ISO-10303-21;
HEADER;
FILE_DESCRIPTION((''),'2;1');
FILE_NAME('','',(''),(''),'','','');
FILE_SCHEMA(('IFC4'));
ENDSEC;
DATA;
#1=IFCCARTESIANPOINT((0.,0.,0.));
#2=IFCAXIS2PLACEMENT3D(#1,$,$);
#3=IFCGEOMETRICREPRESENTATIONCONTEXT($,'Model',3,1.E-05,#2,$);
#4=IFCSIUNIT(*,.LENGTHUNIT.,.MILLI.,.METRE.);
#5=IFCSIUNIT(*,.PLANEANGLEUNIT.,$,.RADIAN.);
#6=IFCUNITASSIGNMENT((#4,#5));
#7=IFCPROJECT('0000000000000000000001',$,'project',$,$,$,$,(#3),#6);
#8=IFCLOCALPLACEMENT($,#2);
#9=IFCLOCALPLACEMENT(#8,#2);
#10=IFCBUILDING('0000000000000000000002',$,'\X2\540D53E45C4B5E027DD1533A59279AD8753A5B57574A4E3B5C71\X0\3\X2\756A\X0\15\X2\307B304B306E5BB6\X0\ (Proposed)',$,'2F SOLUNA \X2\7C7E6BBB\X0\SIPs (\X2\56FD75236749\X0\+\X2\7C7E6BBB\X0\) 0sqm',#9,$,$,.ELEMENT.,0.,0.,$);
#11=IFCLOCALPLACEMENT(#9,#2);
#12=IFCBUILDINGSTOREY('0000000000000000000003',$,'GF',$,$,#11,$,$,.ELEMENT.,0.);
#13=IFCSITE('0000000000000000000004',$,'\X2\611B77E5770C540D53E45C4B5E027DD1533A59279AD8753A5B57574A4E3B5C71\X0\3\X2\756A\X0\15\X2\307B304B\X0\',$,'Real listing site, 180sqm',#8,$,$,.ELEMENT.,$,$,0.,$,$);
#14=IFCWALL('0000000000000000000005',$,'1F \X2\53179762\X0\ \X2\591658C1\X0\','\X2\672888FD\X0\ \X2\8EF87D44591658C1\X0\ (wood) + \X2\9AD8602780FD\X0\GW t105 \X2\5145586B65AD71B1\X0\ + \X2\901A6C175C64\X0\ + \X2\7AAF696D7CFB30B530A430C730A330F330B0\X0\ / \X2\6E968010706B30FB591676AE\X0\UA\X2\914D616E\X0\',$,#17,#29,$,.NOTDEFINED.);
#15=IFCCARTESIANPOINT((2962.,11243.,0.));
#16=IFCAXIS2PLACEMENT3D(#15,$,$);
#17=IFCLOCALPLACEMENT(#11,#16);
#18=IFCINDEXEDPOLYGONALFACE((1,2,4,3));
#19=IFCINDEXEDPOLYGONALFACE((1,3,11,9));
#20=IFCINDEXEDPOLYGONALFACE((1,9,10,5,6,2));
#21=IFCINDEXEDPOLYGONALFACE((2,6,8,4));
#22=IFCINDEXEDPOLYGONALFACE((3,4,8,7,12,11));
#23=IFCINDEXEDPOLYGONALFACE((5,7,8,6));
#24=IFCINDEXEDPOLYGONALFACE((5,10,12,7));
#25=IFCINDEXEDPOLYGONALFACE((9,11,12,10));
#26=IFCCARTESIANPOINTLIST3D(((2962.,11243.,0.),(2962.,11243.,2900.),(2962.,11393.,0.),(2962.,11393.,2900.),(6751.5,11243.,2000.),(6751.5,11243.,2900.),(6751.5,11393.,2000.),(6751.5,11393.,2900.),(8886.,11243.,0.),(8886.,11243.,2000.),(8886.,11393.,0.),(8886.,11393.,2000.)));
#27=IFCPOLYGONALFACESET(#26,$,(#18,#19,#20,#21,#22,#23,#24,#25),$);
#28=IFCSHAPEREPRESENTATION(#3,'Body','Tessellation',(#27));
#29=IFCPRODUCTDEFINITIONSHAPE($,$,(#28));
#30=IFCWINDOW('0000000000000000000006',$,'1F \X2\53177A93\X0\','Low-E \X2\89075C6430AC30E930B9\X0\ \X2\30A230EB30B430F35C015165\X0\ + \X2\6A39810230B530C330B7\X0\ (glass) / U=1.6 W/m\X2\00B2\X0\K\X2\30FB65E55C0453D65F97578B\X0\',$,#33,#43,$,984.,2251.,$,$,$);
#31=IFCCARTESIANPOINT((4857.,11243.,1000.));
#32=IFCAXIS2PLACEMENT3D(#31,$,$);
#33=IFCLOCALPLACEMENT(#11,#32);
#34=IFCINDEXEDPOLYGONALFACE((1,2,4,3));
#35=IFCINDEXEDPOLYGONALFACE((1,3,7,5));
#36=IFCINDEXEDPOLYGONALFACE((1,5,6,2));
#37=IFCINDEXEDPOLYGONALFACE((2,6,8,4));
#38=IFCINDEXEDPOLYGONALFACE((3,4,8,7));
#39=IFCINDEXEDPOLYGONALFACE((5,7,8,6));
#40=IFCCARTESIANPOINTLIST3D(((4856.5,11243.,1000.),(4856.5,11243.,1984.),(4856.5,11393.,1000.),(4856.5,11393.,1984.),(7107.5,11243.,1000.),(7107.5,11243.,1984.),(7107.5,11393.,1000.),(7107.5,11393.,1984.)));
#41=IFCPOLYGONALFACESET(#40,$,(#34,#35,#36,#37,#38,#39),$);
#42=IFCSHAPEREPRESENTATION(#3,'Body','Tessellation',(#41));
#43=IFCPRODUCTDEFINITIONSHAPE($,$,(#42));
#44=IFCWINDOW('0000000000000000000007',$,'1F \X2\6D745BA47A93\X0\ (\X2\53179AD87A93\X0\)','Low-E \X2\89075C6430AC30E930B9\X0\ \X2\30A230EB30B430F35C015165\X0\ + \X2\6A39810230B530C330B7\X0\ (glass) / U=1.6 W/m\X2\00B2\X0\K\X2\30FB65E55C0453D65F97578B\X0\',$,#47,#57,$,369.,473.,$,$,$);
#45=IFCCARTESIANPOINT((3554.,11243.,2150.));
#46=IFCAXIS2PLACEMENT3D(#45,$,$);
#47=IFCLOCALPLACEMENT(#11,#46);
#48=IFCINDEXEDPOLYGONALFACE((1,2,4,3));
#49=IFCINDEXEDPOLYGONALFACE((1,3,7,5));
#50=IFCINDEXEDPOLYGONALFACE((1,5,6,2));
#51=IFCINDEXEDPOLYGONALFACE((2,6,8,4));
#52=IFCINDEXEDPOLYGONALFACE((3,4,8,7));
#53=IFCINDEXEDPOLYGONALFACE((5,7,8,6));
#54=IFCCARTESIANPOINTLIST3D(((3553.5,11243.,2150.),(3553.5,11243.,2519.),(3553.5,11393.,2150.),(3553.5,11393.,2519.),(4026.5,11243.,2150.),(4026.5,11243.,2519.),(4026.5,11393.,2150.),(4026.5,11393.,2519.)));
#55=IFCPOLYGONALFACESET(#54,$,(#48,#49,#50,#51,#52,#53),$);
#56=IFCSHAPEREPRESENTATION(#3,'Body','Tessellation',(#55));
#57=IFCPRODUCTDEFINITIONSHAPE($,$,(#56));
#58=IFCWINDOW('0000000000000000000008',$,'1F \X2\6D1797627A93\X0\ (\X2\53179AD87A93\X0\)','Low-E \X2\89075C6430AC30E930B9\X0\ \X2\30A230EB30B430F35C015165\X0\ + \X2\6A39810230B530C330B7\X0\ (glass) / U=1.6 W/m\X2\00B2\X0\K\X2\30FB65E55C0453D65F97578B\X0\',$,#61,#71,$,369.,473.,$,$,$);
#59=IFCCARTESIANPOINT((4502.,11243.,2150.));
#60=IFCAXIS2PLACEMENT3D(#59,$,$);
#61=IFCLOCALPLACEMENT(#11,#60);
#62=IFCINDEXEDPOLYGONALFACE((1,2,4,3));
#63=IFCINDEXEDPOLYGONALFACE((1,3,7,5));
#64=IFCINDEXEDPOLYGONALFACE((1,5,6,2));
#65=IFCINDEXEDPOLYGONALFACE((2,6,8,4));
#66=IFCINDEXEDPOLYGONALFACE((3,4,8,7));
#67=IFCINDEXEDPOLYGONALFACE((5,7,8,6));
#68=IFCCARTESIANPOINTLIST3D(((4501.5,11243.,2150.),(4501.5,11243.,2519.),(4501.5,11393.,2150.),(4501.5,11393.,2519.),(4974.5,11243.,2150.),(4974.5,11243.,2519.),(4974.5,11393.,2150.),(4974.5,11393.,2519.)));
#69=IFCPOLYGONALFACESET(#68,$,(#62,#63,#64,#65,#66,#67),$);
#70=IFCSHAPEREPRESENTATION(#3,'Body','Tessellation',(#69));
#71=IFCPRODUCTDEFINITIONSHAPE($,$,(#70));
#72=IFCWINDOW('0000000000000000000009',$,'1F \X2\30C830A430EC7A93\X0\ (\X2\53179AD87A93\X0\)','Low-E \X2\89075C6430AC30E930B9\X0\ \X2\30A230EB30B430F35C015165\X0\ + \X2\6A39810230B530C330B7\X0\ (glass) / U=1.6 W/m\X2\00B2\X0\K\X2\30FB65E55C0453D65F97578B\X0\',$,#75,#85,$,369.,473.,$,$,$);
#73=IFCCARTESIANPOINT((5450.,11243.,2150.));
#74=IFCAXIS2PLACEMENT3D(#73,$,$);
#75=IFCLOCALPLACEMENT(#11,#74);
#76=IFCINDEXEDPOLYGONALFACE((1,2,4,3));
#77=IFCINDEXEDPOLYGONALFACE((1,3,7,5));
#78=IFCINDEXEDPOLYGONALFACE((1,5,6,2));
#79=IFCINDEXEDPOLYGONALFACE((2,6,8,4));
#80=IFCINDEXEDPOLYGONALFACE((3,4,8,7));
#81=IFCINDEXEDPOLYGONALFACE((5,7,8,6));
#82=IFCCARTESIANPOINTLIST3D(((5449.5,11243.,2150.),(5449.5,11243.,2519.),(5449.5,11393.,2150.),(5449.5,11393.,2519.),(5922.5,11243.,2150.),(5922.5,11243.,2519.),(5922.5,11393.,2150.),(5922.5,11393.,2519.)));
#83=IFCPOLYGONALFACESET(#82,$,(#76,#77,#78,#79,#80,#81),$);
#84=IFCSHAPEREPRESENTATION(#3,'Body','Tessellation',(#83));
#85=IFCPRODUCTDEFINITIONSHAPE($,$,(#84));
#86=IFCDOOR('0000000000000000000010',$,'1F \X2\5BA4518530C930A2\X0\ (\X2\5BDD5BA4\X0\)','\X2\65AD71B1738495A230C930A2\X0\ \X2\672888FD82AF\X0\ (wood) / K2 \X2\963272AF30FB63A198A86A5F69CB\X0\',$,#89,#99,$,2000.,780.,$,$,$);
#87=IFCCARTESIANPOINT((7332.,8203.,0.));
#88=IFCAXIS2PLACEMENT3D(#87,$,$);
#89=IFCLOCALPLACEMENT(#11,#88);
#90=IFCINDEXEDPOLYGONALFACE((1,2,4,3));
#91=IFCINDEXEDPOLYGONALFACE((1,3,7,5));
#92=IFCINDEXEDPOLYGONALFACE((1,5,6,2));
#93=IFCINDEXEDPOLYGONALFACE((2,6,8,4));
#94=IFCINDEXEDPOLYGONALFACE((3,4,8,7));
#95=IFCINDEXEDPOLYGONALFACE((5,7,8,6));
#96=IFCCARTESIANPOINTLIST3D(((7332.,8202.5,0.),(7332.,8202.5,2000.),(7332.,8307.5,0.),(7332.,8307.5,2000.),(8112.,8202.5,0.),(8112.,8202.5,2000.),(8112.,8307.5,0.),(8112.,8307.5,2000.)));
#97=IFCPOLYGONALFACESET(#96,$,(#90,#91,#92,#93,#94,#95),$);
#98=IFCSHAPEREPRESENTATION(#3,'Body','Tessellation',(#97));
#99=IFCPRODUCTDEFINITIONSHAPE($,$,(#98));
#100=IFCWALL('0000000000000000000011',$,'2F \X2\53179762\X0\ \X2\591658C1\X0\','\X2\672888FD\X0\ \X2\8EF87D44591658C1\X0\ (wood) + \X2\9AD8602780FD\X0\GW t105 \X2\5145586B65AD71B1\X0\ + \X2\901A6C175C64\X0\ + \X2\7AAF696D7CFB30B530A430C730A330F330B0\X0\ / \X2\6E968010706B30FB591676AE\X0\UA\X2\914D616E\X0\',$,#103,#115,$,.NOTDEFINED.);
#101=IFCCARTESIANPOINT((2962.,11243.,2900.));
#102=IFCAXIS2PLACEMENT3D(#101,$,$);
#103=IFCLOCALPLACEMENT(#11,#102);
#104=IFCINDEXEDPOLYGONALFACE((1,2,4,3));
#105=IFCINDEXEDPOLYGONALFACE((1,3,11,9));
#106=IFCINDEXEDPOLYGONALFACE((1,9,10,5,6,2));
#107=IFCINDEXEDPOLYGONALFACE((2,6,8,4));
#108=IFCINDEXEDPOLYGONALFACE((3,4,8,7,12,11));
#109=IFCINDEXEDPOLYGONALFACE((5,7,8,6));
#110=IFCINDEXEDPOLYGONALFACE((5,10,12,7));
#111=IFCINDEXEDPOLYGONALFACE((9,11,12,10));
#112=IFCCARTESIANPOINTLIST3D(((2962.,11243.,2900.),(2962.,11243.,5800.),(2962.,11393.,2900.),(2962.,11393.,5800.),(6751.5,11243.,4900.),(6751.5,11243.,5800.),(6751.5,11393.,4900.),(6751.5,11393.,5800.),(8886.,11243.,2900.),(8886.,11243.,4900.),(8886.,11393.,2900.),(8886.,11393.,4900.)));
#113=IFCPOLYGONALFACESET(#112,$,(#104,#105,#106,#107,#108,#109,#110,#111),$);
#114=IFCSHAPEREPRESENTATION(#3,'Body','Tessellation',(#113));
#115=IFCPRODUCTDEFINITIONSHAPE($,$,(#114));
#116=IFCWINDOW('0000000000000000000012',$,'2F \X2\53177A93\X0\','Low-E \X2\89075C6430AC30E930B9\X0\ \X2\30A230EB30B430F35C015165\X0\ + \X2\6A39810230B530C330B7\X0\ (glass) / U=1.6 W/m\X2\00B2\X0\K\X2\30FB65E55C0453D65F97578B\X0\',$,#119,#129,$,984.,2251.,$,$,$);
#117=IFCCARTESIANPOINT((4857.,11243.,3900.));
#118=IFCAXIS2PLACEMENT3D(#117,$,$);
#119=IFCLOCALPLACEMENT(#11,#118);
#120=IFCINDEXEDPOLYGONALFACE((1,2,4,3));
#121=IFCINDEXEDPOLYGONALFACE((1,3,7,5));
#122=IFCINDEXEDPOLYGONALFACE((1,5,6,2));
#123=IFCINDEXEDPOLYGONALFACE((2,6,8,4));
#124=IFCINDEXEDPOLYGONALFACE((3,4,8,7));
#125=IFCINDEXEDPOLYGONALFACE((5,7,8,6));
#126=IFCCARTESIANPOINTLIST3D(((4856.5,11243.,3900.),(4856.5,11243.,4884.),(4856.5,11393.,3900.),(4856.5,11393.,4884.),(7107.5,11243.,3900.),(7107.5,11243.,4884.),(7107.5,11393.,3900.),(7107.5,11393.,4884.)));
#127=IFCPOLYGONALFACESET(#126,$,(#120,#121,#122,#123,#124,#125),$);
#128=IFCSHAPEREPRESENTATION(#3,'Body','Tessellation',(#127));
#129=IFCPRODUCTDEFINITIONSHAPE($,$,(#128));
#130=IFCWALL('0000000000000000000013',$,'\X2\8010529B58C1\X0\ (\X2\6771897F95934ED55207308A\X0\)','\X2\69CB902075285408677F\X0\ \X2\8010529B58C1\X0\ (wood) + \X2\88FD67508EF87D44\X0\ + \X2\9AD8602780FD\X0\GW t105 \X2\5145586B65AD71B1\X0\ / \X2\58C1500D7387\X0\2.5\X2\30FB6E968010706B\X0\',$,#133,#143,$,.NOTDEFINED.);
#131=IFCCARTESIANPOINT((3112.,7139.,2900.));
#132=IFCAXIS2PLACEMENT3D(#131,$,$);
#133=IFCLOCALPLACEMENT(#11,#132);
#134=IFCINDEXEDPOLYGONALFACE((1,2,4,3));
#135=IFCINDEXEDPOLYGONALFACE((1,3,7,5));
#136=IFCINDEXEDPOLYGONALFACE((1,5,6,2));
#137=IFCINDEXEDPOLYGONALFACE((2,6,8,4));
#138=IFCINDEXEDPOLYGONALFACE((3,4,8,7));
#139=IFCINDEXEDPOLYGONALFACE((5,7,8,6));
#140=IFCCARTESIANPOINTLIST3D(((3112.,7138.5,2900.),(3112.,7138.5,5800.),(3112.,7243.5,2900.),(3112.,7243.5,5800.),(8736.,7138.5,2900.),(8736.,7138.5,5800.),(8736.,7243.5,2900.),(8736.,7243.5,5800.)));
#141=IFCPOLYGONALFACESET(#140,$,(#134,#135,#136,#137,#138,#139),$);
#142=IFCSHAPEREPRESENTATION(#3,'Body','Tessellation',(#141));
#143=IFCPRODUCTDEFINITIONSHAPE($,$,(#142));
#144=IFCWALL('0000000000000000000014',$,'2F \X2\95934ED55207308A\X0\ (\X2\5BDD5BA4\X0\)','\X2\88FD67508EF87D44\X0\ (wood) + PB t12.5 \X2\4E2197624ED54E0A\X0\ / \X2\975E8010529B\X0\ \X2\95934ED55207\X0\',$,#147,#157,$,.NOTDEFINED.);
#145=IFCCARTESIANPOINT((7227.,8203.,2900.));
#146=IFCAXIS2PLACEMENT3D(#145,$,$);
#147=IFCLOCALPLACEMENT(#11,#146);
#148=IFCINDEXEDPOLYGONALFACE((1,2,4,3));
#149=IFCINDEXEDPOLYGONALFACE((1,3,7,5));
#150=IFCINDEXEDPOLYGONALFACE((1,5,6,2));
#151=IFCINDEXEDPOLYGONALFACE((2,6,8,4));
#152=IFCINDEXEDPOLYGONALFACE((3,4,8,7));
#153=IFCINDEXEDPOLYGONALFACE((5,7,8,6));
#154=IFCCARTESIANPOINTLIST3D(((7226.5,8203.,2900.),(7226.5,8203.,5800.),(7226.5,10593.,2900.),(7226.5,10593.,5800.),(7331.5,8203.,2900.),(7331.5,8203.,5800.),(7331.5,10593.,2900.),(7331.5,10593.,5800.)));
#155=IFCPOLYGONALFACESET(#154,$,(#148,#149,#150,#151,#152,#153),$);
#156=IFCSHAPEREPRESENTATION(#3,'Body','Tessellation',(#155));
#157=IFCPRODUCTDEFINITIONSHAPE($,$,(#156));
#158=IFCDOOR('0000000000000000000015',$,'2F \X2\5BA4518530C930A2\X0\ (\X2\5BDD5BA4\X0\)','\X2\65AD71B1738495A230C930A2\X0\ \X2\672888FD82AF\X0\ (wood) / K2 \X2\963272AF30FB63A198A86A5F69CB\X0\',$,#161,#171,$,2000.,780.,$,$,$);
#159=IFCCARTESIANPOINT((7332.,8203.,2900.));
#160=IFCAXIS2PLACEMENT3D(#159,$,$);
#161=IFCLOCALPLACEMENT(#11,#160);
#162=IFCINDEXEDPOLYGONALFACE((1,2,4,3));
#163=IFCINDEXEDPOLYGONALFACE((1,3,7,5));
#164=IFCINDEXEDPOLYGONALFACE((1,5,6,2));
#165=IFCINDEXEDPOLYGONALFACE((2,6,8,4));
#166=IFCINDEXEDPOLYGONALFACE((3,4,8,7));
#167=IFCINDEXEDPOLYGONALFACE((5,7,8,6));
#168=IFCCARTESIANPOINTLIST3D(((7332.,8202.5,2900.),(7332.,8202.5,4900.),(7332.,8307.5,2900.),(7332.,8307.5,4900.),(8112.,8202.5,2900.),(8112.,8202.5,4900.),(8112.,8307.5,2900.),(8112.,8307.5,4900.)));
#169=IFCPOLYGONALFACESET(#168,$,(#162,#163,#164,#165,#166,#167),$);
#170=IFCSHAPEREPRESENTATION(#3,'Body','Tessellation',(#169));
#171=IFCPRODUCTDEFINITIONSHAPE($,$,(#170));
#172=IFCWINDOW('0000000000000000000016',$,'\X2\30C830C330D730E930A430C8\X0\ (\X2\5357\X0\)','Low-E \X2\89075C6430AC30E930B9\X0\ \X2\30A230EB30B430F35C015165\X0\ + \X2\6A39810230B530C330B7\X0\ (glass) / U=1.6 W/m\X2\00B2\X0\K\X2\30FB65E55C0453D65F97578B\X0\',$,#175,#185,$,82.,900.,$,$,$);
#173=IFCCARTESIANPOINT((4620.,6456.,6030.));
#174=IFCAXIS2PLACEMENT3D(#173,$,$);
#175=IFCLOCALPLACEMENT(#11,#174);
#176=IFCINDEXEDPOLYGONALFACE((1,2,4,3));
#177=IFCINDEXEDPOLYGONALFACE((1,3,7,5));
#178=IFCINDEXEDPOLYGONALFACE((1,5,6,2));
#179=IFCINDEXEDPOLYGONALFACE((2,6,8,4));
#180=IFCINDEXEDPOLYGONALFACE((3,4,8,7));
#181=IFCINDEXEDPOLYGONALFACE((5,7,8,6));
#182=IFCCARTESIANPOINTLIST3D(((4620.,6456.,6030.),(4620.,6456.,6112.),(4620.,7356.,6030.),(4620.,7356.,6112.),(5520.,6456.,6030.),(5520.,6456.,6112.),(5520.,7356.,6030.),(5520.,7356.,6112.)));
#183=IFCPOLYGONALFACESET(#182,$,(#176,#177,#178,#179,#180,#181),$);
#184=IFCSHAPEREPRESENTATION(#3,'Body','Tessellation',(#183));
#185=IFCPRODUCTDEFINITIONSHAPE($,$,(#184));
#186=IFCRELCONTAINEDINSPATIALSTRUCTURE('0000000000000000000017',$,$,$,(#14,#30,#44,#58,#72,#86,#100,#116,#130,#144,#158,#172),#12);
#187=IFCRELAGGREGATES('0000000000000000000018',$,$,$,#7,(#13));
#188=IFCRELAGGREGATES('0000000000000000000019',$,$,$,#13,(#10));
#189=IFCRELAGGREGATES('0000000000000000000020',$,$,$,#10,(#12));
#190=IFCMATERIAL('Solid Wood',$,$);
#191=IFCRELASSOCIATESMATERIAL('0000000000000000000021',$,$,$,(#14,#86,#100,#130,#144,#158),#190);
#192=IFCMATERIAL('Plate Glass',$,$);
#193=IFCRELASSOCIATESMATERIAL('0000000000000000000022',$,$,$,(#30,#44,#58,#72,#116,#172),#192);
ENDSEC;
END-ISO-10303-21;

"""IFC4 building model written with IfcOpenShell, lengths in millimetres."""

from ifc_helpers import new_model, si_unit, frame, frame_2d, origin, place, context, project, spatial, rectangle, extrude, material, element, fill, save


model = new_model("IFC4")

# Units and contexts
model_context = context("Model", 3, precision=1e-05, world=origin())
ifc_project = project(units=[si_unit("LENGTHUNIT", "METRE", prefix="MILLI"), si_unit("PLANEANGLEUNIT", "RADIAN")], contexts=[model_context])

# Site, building, storey
site_placement = place(None, origin())
site = spatial("IfcSite", under=ifc_project, at=site_placement, Name="愛知県名古屋市緑区大高町字坊主山3番15ほか", ObjectType="Real listing site, 180sqm", CompositionType="ELEMENT", RefElevation=0.0)
building_placement = place(site_placement, origin())
building = spatial("IfcBuilding", under=site, at=building_placement, Name="名古屋市緑区大高町字坊主山3番15ほかの家 (Proposed)", ObjectType="2F SOLUNA 籾殻SIPs (国産杉+籾殻) 0sqm", CompositionType="ELEMENT", ElevationOfRefHeight=0.0, ElevationOfTerrain=0.0)
storey_placement = place(building_placement, origin())
storey = spatial("IfcBuildingStorey", under=building, at=storey_placement, Name="GF", CompositionType="ELEMENT", Elevation=0.0)

# Wall, openings, windows
ifc_material_1 = material(Name="Solid Wood")
wall_1_placement = place(storey_placement, frame((2962.0, 11243.0, 0.0)))
wall_1 = element("IfcWall", 1, at=wall_1_placement, inside=storey, material=ifc_material_1, Name="1F 北面 外壁", Description="木製 軸組外壁 (wood) + 高性能GW t105 充填断熱 + 通気層 + 窯業系サイディング / 準耐火・外皮UA配慮", PredefinedType="NOTDEFINED", context=model_context, shape_type="SweptSolid", body=[
    extrude(rectangle(XDim=5924.0, YDim=150.0, at=frame_2d((2962.0, 75.0))), frame((2962.0, 11243.0, 0.0)), (0.0, 0.0, 1.0), 2900.0),
])
opening_1_placement = place(storey_placement, frame((4857.0, 11243.0, 1000.0)))
opening_1 = element("IfcOpeningElement", 2, at=opening_1_placement, cuts=wall_1, PredefinedType="NOTDEFINED", context=model_context, shape_type="SweptSolid", body=[
    extrude(rectangle(XDim=2251.0, YDim=150.0, at=frame_2d((1125.0, 75.0))), frame((4857.0, 11243.0, 1000.0)), (0.0, 0.0, 1.0), 984.0),
])
opening_2_placement = place(storey_placement, frame((3554.0, 11243.0, 2150.0)))
opening_2 = element("IfcOpeningElement", 3, at=opening_2_placement, cuts=wall_1, PredefinedType="NOTDEFINED", context=model_context, shape_type="SweptSolid", body=[
    extrude(rectangle(XDim=473.0, YDim=150.0, at=frame_2d((236.0, 75.0))), frame((3554.0, 11243.0, 2150.0)), (0.0, 0.0, 1.0), 369.0),
])
opening_3_placement = place(storey_placement, frame((4502.0, 11243.0, 2150.0)))
opening_3 = element("IfcOpeningElement", 4, at=opening_3_placement, cuts=wall_1, PredefinedType="NOTDEFINED", context=model_context, shape_type="SweptSolid", body=[
    extrude(rectangle(XDim=473.0, YDim=150.0, at=frame_2d((236.0, 75.0))), frame((4502.0, 11243.0, 2150.0)), (0.0, 0.0, 1.0), 369.0),
])
opening_4_placement = place(storey_placement, frame((5450.0, 11243.0, 2150.0)))
opening_4 = element("IfcOpeningElement", 5, at=opening_4_placement, cuts=wall_1, PredefinedType="NOTDEFINED", context=model_context, shape_type="SweptSolid", body=[
    extrude(rectangle(XDim=473.0, YDim=150.0, at=frame_2d((236.0, 75.0))), frame((5450.0, 11243.0, 2150.0)), (0.0, 0.0, 1.0), 369.0),
])
ifc_material_2 = material(Name="Plate Glass")
window_1_placement = place(storey_placement, frame((4857.0, 11243.0, 1000.0)))
window_1 = element("IfcWindow", 6, at=window_1_placement, inside=storey, material=ifc_material_2, Name="1F 北窓", Description="Low-E 複層ガラス アルゴン封入 + 樹脂サッシ (glass) / U=1.6 W/m²K・日射取得型", OverallHeight=984.0, OverallWidth=2251.0, context=model_context, shape_type="SweptSolid", body=[
    extrude(rectangle(XDim=2251.0, YDim=150.0, at=frame_2d((1125.0, 75.0))), frame((4857.0, 11243.0, 1000.0)), (0.0, 0.0, 1.0), 984.0),
])
fill(opening_1, window_1)
window_2_placement = place(storey_placement, frame((3554.0, 11243.0, 2150.0)))
window_2 = element("IfcWindow", 7, at=window_2_placement, inside=storey, material=ifc_material_2, Name="1F 浴室窓 (北高窓)", Description="Low-E 複層ガラス アルゴン封入 + 樹脂サッシ (glass) / U=1.6 W/m²K・日射取得型", OverallHeight=369.0, OverallWidth=473.0, context=model_context, shape_type="SweptSolid", body=[
    extrude(rectangle(XDim=473.0, YDim=150.0, at=frame_2d((236.0, 75.0))), frame((3554.0, 11243.0, 2150.0)), (0.0, 0.0, 1.0), 369.0),
])
fill(opening_2, window_2)
window_3_placement = place(storey_placement, frame((4502.0, 11243.0, 2150.0)))
window_3 = element("IfcWindow", 8, at=window_3_placement, inside=storey, material=ifc_material_2, Name="1F 洗面窓 (北高窓)", Description="Low-E 複層ガラス アルゴン封入 + 樹脂サッシ (glass) / U=1.6 W/m²K・日射取得型", OverallHeight=369.0, OverallWidth=473.0, context=model_context, shape_type="SweptSolid", body=[
    extrude(rectangle(XDim=473.0, YDim=150.0, at=frame_2d((236.0, 75.0))), frame((4502.0, 11243.0, 2150.0)), (0.0, 0.0, 1.0), 369.0),
])
fill(opening_3, window_3)
window_4_placement = place(storey_placement, frame((5450.0, 11243.0, 2150.0)))
window_4 = element("IfcWindow", 9, at=window_4_placement, inside=storey, material=ifc_material_2, Name="1F トイレ窓 (北高窓)", Description="Low-E 複層ガラス アルゴン封入 + 樹脂サッシ (glass) / U=1.6 W/m²K・日射取得型", OverallHeight=369.0, OverallWidth=473.0, context=model_context, shape_type="SweptSolid", body=[
    extrude(rectangle(XDim=473.0, YDim=150.0, at=frame_2d((236.0, 75.0))), frame((5450.0, 11243.0, 2150.0)), (0.0, 0.0, 1.0), 369.0),
])
fill(opening_4, window_4)

# Door
door_1_placement = place(storey_placement, frame((7332.0, 8203.0, 0.0)))
element("IfcDoor", 10, at=door_1_placement, inside=storey, material=ifc_material_1, Name="1F 室内ドア (寝室)", Description="断熱玄関ドア 木製芯 (wood) / K2 防犯・採風機構", OverallHeight=2000.0, OverallWidth=780.0, context=model_context, shape_type="SweptSolid", body=[
    extrude(rectangle(XDim=780.0, YDim=105.0, at=frame_2d((390.0, 52.0))), frame((7332.0, 8203.0, 0.0)), (0.0, 0.0, 1.0), 2000.0),
])

# Wall, opening, window
wall_2_placement = place(storey_placement, frame((2962.0, 11243.0, 2900.0)))
wall_2 = element("IfcWall", 11, at=wall_2_placement, inside=storey, material=ifc_material_1, Name="2F 北面 外壁", Description="木製 軸組外壁 (wood) + 高性能GW t105 充填断熱 + 通気層 + 窯業系サイディング / 準耐火・外皮UA配慮", PredefinedType="NOTDEFINED", context=model_context, shape_type="SweptSolid", body=[
    extrude(rectangle(XDim=5924.0, YDim=150.0, at=frame_2d((2962.0, 75.0))), frame((2962.0, 11243.0, 2900.0)), (0.0, 0.0, 1.0), 2900.0),
])
opening_5_placement = place(storey_placement, frame((4857.0, 11243.0, 3900.0)))
opening_5 = element("IfcOpeningElement", 12, at=opening_5_placement, cuts=wall_2, PredefinedType="NOTDEFINED", context=model_context, shape_type="SweptSolid", body=[
    extrude(rectangle(XDim=2251.0, YDim=150.0, at=frame_2d((1125.0, 75.0))), frame((4857.0, 11243.0, 3900.0)), (0.0, 0.0, 1.0), 984.0),
])
window_5_placement = place(storey_placement, frame((4857.0, 11243.0, 3900.0)))
window_5 = element("IfcWindow", 13, at=window_5_placement, inside=storey, material=ifc_material_2, Name="2F 北窓", Description="Low-E 複層ガラス アルゴン封入 + 樹脂サッシ (glass) / U=1.6 W/m²K・日射取得型", OverallHeight=984.0, OverallWidth=2251.0, context=model_context, shape_type="SweptSolid", body=[
    extrude(rectangle(XDim=2251.0, YDim=150.0, at=frame_2d((1125.0, 75.0))), frame((4857.0, 11243.0, 3900.0)), (0.0, 0.0, 1.0), 984.0),
])
fill(opening_5, window_5)

# Walls
wall_3_placement = place(storey_placement, frame((3112.0, 7139.0, 2900.0)))
element("IfcWall", 14, at=wall_3_placement, inside=storey, material=ifc_material_1, Name="耐力壁 (東西間仕切り)", Description="構造用合板 耐力壁 (wood) + 製材軸組 + 高性能GW t105 充填断熱 / 壁倍率2.5・準耐火", PredefinedType="NOTDEFINED", context=model_context, shape_type="SweptSolid", body=[
    extrude(rectangle(XDim=5624.0, YDim=105.0, at=frame_2d((2812.0, 52.0))), frame((3112.0, 7139.0, 2900.0)), (0.0, 0.0, 1.0), 2900.0),
])
wall_4_placement = place(storey_placement, frame((7227.0, 8203.0, 2900.0)))
element("IfcWall", 15, at=wall_4_placement, inside=storey, material=ifc_material_1, Name="2F 間仕切り (寝室)", Description="製材軸組 (wood) + PB t12.5 両面仕上 / 非耐力 間仕切", PredefinedType="NOTDEFINED", context=model_context, shape_type="SweptSolid", body=[
    extrude(rectangle(XDim=105.0, YDim=2390.0, at=frame_2d((52.0, 1195.0))), frame((7227.0, 8203.0, 2900.0)), (0.0, 0.0, 1.0), 2900.0),
])

# Door
door_2_placement = place(storey_placement, frame((7332.0, 8203.0, 2900.0)))
element("IfcDoor", 16, at=door_2_placement, inside=storey, material=ifc_material_1, Name="2F 室内ドア (寝室)", Description="断熱玄関ドア 木製芯 (wood) / K2 防犯・採風機構", OverallHeight=2000.0, OverallWidth=780.0, context=model_context, shape_type="SweptSolid", body=[
    extrude(rectangle(XDim=780.0, YDim=105.0, at=frame_2d((390.0, 52.0))), frame((7332.0, 8203.0, 2900.0)), (0.0, 0.0, 1.0), 2000.0),
])

# Window
window_6_placement = place(storey_placement, frame((4620.0, 6456.0, 6030.0)))
element("IfcWindow", 17, at=window_6_placement, inside=storey, material=ifc_material_2, Name="トップライト (南)", Description="Low-E 複層ガラス アルゴン封入 + 樹脂サッシ (glass) / U=1.6 W/m²K・日射取得型", OverallHeight=82.0, OverallWidth=900.0, context=model_context, shape_type="SweptSolid", body=[
    extrude(rectangle(XDim=900.0, YDim=900.0, at=frame_2d((450.0, 450.0))), frame((4620.0, 6456.0, 6030.0)), (0.0, 0.0, 1.0), 82.0),
])

save(model, "model.ifc")
